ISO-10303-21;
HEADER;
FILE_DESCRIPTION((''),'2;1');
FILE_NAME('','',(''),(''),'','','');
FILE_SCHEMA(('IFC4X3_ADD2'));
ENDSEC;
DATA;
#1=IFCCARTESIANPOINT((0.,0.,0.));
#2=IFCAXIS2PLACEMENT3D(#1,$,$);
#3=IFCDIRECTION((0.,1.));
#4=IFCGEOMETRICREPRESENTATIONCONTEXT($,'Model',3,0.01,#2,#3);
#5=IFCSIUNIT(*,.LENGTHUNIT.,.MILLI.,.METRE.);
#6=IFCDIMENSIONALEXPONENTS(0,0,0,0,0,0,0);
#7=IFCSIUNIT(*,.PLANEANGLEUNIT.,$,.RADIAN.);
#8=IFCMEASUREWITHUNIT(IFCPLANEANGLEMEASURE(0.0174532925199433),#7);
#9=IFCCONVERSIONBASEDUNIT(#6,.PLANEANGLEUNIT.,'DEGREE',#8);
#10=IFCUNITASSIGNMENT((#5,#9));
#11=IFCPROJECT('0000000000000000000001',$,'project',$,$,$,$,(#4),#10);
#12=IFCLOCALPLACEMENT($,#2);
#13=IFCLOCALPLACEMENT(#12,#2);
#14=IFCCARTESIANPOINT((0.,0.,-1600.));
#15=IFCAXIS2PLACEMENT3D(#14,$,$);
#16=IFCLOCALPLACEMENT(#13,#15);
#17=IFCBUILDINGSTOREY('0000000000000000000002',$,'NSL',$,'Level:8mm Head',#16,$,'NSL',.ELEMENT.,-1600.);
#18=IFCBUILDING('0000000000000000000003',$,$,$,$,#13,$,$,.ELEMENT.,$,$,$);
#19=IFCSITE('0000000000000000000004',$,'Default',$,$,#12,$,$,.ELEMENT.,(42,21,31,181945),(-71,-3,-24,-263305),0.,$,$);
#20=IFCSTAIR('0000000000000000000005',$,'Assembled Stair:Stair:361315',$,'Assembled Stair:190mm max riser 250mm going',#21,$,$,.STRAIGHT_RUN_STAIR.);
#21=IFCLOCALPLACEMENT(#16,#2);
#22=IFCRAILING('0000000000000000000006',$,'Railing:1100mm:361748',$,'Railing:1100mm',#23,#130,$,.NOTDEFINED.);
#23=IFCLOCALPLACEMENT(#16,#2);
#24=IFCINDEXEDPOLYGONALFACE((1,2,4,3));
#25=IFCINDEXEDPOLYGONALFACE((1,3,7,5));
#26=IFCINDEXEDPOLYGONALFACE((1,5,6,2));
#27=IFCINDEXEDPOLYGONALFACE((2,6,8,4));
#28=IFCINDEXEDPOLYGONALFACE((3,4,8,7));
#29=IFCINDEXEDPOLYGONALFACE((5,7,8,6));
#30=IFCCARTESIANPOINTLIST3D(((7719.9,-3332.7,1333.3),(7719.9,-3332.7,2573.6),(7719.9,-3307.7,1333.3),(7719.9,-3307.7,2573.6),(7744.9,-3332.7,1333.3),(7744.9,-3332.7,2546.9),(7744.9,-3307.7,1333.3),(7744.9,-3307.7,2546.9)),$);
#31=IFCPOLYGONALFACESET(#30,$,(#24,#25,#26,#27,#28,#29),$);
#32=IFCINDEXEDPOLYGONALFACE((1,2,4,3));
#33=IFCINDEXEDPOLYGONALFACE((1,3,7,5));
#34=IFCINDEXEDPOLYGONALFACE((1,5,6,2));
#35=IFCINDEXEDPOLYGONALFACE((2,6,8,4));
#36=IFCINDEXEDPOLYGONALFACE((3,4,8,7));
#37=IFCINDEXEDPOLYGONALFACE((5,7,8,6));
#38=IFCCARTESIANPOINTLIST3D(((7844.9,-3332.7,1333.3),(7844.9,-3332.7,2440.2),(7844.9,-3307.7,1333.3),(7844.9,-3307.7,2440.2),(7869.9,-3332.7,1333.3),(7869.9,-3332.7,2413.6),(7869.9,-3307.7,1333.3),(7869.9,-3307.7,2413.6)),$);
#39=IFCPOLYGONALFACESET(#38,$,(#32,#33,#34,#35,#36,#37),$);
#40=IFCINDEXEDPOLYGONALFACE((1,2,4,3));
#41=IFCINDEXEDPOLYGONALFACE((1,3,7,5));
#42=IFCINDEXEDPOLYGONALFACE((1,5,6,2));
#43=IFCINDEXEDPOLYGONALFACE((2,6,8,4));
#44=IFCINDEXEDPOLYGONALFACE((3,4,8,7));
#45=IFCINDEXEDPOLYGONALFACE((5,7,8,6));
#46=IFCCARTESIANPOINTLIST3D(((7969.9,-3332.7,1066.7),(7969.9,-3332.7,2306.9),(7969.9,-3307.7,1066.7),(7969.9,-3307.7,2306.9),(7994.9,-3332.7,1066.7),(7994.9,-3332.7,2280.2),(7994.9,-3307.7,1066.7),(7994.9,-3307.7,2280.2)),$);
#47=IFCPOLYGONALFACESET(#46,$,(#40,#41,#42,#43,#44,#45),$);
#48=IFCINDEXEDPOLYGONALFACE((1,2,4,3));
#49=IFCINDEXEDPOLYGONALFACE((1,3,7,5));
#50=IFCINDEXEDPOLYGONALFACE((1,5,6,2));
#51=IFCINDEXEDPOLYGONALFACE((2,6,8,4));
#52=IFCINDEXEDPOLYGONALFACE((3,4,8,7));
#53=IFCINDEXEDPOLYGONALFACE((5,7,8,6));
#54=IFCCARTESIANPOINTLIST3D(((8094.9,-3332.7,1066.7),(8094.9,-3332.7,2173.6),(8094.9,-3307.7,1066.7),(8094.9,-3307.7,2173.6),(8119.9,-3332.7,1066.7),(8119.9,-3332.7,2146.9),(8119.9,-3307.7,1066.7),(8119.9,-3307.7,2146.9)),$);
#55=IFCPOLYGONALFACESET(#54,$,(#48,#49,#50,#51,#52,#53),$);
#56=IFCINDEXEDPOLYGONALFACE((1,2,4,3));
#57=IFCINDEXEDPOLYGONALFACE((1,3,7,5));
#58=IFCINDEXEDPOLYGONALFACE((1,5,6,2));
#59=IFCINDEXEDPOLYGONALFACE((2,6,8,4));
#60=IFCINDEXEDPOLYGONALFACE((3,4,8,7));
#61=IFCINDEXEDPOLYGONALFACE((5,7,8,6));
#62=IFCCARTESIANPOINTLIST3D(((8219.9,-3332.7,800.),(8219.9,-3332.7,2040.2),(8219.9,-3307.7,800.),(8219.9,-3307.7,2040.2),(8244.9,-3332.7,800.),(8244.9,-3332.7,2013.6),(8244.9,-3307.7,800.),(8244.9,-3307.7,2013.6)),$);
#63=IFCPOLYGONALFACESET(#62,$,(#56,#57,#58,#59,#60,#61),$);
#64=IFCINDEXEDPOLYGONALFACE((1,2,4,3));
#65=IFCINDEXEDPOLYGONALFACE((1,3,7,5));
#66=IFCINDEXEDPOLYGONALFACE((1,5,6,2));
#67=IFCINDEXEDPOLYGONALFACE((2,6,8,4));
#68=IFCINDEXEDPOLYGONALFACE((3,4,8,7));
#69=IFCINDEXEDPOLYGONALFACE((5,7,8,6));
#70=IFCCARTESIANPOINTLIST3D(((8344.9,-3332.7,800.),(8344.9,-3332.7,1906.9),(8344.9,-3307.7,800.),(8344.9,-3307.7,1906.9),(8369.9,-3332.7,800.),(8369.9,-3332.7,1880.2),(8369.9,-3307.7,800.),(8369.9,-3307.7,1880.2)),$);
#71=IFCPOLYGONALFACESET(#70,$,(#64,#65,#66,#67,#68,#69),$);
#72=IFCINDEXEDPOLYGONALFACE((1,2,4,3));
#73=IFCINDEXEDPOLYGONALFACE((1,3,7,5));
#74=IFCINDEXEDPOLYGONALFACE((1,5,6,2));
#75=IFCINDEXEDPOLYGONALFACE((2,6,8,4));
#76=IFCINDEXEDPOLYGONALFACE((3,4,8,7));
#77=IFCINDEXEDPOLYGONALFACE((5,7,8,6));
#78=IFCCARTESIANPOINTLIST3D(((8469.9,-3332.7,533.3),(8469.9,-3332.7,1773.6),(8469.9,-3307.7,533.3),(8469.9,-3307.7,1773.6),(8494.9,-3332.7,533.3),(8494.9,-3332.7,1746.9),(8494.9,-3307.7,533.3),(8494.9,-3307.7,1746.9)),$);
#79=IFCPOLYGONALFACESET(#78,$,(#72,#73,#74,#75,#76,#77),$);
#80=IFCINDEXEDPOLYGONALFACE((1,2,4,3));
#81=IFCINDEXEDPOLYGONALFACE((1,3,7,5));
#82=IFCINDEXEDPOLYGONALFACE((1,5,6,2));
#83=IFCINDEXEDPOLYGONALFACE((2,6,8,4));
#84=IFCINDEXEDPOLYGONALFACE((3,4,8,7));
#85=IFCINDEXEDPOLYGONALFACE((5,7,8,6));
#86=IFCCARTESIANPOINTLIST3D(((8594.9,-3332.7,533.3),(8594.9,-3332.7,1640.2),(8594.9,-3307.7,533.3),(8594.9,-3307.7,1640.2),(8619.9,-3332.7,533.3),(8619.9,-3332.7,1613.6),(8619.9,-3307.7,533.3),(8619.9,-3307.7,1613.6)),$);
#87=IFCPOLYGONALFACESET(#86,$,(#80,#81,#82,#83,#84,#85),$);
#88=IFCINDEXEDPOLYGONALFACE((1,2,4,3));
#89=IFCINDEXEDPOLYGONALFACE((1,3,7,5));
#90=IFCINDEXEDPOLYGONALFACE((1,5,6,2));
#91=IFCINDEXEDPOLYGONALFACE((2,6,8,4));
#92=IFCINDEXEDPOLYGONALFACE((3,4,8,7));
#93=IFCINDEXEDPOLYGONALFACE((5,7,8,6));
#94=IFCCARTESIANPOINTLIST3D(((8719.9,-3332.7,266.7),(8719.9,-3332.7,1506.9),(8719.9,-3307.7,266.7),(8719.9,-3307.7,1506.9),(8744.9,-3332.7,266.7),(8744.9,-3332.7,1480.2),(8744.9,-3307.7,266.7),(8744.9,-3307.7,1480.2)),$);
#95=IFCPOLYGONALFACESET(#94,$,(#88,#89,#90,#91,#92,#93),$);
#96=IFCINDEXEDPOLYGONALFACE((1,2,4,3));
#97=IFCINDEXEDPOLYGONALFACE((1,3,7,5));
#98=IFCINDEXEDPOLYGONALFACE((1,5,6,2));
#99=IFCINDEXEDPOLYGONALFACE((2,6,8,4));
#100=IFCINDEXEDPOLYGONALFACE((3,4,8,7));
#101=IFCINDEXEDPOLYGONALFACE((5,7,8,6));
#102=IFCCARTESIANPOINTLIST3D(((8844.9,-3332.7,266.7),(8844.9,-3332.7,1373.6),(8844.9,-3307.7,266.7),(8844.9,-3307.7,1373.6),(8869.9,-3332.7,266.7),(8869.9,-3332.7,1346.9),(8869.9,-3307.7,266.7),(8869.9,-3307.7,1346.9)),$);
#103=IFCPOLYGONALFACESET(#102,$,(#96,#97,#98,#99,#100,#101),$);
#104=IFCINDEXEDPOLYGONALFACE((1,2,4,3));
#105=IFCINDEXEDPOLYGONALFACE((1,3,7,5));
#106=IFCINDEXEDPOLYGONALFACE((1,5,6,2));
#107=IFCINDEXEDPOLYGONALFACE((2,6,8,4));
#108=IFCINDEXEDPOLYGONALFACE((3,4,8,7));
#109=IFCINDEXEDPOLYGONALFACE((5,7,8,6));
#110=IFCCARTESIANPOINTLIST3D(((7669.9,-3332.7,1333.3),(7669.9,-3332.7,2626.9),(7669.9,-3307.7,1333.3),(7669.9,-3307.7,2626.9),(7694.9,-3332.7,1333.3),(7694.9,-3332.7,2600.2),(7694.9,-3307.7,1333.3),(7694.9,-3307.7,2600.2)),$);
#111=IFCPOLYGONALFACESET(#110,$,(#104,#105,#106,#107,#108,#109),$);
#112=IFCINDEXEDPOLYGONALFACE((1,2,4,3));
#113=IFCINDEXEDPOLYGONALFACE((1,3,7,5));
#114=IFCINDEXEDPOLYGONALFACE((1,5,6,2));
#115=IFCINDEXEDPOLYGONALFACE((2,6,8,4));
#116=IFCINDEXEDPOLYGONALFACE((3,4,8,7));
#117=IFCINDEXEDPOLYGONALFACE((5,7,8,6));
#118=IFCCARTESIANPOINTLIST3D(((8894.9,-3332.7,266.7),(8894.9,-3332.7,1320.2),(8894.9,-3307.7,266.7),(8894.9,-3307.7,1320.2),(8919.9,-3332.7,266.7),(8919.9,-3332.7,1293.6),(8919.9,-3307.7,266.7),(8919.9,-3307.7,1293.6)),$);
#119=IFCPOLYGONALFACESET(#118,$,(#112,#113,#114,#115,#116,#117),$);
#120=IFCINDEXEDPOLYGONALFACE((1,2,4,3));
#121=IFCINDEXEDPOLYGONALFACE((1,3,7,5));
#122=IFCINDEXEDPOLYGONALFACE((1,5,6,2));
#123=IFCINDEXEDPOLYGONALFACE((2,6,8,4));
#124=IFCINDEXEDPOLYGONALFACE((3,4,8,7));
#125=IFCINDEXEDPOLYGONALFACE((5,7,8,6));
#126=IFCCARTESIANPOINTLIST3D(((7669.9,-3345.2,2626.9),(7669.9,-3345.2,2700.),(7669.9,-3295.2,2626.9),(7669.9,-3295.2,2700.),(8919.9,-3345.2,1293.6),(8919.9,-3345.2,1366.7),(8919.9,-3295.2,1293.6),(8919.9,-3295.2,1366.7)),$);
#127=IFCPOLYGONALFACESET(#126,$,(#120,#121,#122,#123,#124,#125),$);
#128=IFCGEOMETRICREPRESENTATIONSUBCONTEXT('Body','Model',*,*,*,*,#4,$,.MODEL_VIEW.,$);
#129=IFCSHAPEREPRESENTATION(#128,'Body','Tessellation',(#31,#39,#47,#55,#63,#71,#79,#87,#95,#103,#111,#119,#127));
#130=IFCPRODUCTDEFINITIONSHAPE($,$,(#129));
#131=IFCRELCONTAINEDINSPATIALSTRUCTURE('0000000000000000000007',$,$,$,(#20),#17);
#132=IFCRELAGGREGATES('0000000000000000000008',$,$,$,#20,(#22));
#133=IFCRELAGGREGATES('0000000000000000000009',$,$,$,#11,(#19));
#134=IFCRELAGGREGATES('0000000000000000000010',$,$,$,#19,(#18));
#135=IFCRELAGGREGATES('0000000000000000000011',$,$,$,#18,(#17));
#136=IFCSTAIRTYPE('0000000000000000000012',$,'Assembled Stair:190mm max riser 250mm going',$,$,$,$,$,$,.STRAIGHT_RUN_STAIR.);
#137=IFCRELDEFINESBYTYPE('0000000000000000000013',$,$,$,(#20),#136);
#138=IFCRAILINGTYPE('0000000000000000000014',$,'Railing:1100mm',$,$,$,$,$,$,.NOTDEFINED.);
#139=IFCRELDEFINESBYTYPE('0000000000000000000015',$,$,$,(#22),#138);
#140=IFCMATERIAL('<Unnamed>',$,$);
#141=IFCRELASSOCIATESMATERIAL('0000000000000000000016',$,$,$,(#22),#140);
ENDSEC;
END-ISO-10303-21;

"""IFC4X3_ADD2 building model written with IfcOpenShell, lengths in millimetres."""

from ifc_helpers import new_model, entity, si_unit, converted_unit, direction, frame, origin, place, context, subcontext, project, spatial, polyline, outline, extrude, material, type_object, element, aggregate, save


model = new_model("IFC4X3_ADD2")

# Units and contexts
model_context = context("Model", 3, precision=0.01, world=origin(), true_north=direction((0.0, 1.0)))
body_context = subcontext(model_context, "Body", "Model", "MODEL_VIEW")
ifc_project = project(units=[si_unit("LENGTHUNIT", "METRE", prefix="MILLI"), converted_unit("PLANEANGLEUNIT", "DEGREE", entity("IfcPlaneAngleMeasure", 0.0174532925199433), si_unit("PLANEANGLEUNIT", "RADIAN"), dimensions=[0, 0, 0, 0, 0, 0, 0])], contexts=[model_context])

# Site, building, storey
site_placement = place(None, origin())
site = spatial("IfcSite", under=ifc_project, at=site_placement, Name="Default", CompositionType="ELEMENT", RefLatitude=(42, 21, 31, 181945), RefLongitude=(-71, -3, -24, -263305), RefElevation=0.0)
building_placement = place(site_placement, origin())
building = spatial("IfcBuilding", under=site, at=building_placement, CompositionType="ELEMENT")
storey_placement = place(building_placement, frame((0.0, 0.0, -1600.0)))
storey = spatial("IfcBuildingStorey", under=building, at=storey_placement, Name="NSL", ObjectType="Level:8mm Head", LongName="NSL", CompositionType="ELEMENT", Elevation=-1600.0)

# Stair
stair_type = type_object("IfcStairType", Name="Assembled Stair:190mm max riser 250mm going", PredefinedType="STRAIGHT_RUN_STAIR")
stair_placement = place(storey_placement, origin())
stair = element("IfcStair", 1, at=stair_placement, inside=storey, type_object=stair_type, Name="Assembled Stair:Stair:361315", ObjectType="Assembled Stair:190mm max riser 250mm going", PredefinedType="STRAIGHT_RUN_STAIR")
ifc_material_1 = material(Name="<Unnamed>")

# Railing
railing_type = type_object("IfcRailingType", Name="Railing:1100mm", PredefinedType="NOTDEFINED")
railing_1_placement = place(stair_placement, frame((7669.9, -3345.2, 266.7)))
railing_1 = element("IfcRailing", 2, at=railing_1_placement, type_object=railing_type, material=ifc_material_1, Name="Railing:1100mm:361748", ObjectType="Railing:1100mm", PredefinedType="NOTDEFINED", context=body_context, shape_type="SweptSolid", body=[
    extrude(outline(polyline([(-600.1, -12.5), (613.4, -12.5), (613.4, 12.5), (-626.8, 12.5), (-600.1, -12.5)])), frame((62.5, 12.5, 1680.1), z_axis=(0.0, 1.0, 0.0), x_axis=(0.0, 0.0, -1.0)), (0.0, 0.0, 1.0), 25.0),
    extrude(outline(polyline([(-533.4, -12.5), (546.8, -12.5), (546.8, 12.5), (-560.1, 12.5), (-533.4, -12.5)])), frame((187.5, 12.5, 1613.4), z_axis=(0.0, 1.0, 0.0), x_axis=(0.0, 0.0, -1.0)), (0.0, 0.0, 1.0), 25.0),
    extrude(outline(polyline([(-600.1, -12.5), (613.4, -12.5), (613.4, 12.5), (-626.8, 12.5), (-600.1, -12.5)])), frame((312.5, 12.5, 1413.4), z_axis=(0.0, 1.0, 0.0), x_axis=(0.0, 0.0, -1.0)), (0.0, 0.0, 1.0), 25.0),
    extrude(outline(polyline([(-533.4, -12.5), (546.8, -12.5), (546.8, 12.5), (-560.1, 12.5), (-533.4, -12.5)])), frame((437.5, 12.5, 1346.8), z_axis=(0.0, 1.0, 0.0), x_axis=(0.0, 0.0, -1.0)), (0.0, 0.0, 1.0), 25.0),
    extrude(outline(polyline([(-600.1, -12.5), (613.4, -12.5), (613.4, 12.5), (-626.8, 12.5), (-600.1, -12.5)])), frame((562.5, 12.5, 1146.8), z_axis=(0.0, 1.0, 0.0), x_axis=(0.0, 0.0, -1.0)), (0.0, 0.0, 1.0), 25.0),
    extrude(outline(polyline([(-533.4, -12.5), (546.8, -12.5), (546.8, 12.5), (-560.1, 12.5), (-533.4, -12.5)])), frame((687.5, 12.5, 1080.1), z_axis=(0.0, 1.0, 0.0), x_axis=(0.0, 0.0, -1.0)), (0.0, 0.0, 1.0), 25.0),
    extrude(outline(polyline([(-600.1, -12.5), (613.4, -12.5), (613.4, 12.5), (-626.8, 12.5), (-600.1, -12.5)])), frame((812.5, 12.5, 880.1), z_axis=(0.0, 1.0, 0.0), x_axis=(0.0, 0.0, -1.0)), (0.0, 0.0, 1.0), 25.0),
    extrude(outline(polyline([(-533.4, -12.5), (546.8, -12.5), (546.8, 12.5), (-560.1, 12.5), (-533.4, -12.5)])), frame((937.5, 12.5, 813.4), z_axis=(0.0, 1.0, 0.0), x_axis=(0.0, 0.0, -1.0)), (0.0, 0.0, 1.0), 25.0),
    extrude(outline(polyline([(-600.1, -12.5), (613.4, -12.5), (613.4, 12.5), (-626.8, 12.5), (-600.1, -12.5)])), frame((1062.5, 12.5, 613.4), z_axis=(0.0, 1.0, 0.0), x_axis=(0.0, 0.0, -1.0)), (0.0, 0.0, 1.0), 25.0),
    extrude(outline(polyline([(-533.4, -12.5), (546.8, -12.5), (546.8, 12.5), (-560.1, 12.5), (-533.4, -12.5)])), frame((1187.5, 12.5, 546.8), z_axis=(0.0, 1.0, 0.0), x_axis=(0.0, 0.0, -1.0)), (0.0, 0.0, 1.0), 25.0),
    extrude(outline(polyline([(-626.8, -12.5), (640.1, -12.5), (640.1, 12.5), (-653.4, 12.5), (-626.8, -12.5)])), frame((12.5, 12.5, 1706.8), z_axis=(0.0, 1.0, 0.0), x_axis=(0.0, 0.0, -1.0)), (0.0, 0.0, 1.0), 25.0),
    extrude(outline(polyline([(-506.8, -12.5), (520.1, -12.5), (520.1, 12.5), (-533.4, 12.5), (-506.8, -12.5)])), frame((1237.5, 12.5, 520.1), z_axis=(0.0, 1.0, 0.0), x_axis=(0.0, 0.0, -1.0)), (0.0, 0.0, 1.0), 25.0),
    extrude(outline(polyline([(-940.5, -25.0), (887.2, -25.0), (940.5, 25.0), (-887.2, 25.0), (-940.5, -25.0)])), frame((625.0, 0.0, 1730.1), z_axis=(0.0, 1.0, 0.0), x_axis=(-0.683941, 0.0, 0.729537)), (0.0, 0.0, 1.0), 50.0),
])
aggregate(stair, [railing_1])

save(model, "model.ifc")
